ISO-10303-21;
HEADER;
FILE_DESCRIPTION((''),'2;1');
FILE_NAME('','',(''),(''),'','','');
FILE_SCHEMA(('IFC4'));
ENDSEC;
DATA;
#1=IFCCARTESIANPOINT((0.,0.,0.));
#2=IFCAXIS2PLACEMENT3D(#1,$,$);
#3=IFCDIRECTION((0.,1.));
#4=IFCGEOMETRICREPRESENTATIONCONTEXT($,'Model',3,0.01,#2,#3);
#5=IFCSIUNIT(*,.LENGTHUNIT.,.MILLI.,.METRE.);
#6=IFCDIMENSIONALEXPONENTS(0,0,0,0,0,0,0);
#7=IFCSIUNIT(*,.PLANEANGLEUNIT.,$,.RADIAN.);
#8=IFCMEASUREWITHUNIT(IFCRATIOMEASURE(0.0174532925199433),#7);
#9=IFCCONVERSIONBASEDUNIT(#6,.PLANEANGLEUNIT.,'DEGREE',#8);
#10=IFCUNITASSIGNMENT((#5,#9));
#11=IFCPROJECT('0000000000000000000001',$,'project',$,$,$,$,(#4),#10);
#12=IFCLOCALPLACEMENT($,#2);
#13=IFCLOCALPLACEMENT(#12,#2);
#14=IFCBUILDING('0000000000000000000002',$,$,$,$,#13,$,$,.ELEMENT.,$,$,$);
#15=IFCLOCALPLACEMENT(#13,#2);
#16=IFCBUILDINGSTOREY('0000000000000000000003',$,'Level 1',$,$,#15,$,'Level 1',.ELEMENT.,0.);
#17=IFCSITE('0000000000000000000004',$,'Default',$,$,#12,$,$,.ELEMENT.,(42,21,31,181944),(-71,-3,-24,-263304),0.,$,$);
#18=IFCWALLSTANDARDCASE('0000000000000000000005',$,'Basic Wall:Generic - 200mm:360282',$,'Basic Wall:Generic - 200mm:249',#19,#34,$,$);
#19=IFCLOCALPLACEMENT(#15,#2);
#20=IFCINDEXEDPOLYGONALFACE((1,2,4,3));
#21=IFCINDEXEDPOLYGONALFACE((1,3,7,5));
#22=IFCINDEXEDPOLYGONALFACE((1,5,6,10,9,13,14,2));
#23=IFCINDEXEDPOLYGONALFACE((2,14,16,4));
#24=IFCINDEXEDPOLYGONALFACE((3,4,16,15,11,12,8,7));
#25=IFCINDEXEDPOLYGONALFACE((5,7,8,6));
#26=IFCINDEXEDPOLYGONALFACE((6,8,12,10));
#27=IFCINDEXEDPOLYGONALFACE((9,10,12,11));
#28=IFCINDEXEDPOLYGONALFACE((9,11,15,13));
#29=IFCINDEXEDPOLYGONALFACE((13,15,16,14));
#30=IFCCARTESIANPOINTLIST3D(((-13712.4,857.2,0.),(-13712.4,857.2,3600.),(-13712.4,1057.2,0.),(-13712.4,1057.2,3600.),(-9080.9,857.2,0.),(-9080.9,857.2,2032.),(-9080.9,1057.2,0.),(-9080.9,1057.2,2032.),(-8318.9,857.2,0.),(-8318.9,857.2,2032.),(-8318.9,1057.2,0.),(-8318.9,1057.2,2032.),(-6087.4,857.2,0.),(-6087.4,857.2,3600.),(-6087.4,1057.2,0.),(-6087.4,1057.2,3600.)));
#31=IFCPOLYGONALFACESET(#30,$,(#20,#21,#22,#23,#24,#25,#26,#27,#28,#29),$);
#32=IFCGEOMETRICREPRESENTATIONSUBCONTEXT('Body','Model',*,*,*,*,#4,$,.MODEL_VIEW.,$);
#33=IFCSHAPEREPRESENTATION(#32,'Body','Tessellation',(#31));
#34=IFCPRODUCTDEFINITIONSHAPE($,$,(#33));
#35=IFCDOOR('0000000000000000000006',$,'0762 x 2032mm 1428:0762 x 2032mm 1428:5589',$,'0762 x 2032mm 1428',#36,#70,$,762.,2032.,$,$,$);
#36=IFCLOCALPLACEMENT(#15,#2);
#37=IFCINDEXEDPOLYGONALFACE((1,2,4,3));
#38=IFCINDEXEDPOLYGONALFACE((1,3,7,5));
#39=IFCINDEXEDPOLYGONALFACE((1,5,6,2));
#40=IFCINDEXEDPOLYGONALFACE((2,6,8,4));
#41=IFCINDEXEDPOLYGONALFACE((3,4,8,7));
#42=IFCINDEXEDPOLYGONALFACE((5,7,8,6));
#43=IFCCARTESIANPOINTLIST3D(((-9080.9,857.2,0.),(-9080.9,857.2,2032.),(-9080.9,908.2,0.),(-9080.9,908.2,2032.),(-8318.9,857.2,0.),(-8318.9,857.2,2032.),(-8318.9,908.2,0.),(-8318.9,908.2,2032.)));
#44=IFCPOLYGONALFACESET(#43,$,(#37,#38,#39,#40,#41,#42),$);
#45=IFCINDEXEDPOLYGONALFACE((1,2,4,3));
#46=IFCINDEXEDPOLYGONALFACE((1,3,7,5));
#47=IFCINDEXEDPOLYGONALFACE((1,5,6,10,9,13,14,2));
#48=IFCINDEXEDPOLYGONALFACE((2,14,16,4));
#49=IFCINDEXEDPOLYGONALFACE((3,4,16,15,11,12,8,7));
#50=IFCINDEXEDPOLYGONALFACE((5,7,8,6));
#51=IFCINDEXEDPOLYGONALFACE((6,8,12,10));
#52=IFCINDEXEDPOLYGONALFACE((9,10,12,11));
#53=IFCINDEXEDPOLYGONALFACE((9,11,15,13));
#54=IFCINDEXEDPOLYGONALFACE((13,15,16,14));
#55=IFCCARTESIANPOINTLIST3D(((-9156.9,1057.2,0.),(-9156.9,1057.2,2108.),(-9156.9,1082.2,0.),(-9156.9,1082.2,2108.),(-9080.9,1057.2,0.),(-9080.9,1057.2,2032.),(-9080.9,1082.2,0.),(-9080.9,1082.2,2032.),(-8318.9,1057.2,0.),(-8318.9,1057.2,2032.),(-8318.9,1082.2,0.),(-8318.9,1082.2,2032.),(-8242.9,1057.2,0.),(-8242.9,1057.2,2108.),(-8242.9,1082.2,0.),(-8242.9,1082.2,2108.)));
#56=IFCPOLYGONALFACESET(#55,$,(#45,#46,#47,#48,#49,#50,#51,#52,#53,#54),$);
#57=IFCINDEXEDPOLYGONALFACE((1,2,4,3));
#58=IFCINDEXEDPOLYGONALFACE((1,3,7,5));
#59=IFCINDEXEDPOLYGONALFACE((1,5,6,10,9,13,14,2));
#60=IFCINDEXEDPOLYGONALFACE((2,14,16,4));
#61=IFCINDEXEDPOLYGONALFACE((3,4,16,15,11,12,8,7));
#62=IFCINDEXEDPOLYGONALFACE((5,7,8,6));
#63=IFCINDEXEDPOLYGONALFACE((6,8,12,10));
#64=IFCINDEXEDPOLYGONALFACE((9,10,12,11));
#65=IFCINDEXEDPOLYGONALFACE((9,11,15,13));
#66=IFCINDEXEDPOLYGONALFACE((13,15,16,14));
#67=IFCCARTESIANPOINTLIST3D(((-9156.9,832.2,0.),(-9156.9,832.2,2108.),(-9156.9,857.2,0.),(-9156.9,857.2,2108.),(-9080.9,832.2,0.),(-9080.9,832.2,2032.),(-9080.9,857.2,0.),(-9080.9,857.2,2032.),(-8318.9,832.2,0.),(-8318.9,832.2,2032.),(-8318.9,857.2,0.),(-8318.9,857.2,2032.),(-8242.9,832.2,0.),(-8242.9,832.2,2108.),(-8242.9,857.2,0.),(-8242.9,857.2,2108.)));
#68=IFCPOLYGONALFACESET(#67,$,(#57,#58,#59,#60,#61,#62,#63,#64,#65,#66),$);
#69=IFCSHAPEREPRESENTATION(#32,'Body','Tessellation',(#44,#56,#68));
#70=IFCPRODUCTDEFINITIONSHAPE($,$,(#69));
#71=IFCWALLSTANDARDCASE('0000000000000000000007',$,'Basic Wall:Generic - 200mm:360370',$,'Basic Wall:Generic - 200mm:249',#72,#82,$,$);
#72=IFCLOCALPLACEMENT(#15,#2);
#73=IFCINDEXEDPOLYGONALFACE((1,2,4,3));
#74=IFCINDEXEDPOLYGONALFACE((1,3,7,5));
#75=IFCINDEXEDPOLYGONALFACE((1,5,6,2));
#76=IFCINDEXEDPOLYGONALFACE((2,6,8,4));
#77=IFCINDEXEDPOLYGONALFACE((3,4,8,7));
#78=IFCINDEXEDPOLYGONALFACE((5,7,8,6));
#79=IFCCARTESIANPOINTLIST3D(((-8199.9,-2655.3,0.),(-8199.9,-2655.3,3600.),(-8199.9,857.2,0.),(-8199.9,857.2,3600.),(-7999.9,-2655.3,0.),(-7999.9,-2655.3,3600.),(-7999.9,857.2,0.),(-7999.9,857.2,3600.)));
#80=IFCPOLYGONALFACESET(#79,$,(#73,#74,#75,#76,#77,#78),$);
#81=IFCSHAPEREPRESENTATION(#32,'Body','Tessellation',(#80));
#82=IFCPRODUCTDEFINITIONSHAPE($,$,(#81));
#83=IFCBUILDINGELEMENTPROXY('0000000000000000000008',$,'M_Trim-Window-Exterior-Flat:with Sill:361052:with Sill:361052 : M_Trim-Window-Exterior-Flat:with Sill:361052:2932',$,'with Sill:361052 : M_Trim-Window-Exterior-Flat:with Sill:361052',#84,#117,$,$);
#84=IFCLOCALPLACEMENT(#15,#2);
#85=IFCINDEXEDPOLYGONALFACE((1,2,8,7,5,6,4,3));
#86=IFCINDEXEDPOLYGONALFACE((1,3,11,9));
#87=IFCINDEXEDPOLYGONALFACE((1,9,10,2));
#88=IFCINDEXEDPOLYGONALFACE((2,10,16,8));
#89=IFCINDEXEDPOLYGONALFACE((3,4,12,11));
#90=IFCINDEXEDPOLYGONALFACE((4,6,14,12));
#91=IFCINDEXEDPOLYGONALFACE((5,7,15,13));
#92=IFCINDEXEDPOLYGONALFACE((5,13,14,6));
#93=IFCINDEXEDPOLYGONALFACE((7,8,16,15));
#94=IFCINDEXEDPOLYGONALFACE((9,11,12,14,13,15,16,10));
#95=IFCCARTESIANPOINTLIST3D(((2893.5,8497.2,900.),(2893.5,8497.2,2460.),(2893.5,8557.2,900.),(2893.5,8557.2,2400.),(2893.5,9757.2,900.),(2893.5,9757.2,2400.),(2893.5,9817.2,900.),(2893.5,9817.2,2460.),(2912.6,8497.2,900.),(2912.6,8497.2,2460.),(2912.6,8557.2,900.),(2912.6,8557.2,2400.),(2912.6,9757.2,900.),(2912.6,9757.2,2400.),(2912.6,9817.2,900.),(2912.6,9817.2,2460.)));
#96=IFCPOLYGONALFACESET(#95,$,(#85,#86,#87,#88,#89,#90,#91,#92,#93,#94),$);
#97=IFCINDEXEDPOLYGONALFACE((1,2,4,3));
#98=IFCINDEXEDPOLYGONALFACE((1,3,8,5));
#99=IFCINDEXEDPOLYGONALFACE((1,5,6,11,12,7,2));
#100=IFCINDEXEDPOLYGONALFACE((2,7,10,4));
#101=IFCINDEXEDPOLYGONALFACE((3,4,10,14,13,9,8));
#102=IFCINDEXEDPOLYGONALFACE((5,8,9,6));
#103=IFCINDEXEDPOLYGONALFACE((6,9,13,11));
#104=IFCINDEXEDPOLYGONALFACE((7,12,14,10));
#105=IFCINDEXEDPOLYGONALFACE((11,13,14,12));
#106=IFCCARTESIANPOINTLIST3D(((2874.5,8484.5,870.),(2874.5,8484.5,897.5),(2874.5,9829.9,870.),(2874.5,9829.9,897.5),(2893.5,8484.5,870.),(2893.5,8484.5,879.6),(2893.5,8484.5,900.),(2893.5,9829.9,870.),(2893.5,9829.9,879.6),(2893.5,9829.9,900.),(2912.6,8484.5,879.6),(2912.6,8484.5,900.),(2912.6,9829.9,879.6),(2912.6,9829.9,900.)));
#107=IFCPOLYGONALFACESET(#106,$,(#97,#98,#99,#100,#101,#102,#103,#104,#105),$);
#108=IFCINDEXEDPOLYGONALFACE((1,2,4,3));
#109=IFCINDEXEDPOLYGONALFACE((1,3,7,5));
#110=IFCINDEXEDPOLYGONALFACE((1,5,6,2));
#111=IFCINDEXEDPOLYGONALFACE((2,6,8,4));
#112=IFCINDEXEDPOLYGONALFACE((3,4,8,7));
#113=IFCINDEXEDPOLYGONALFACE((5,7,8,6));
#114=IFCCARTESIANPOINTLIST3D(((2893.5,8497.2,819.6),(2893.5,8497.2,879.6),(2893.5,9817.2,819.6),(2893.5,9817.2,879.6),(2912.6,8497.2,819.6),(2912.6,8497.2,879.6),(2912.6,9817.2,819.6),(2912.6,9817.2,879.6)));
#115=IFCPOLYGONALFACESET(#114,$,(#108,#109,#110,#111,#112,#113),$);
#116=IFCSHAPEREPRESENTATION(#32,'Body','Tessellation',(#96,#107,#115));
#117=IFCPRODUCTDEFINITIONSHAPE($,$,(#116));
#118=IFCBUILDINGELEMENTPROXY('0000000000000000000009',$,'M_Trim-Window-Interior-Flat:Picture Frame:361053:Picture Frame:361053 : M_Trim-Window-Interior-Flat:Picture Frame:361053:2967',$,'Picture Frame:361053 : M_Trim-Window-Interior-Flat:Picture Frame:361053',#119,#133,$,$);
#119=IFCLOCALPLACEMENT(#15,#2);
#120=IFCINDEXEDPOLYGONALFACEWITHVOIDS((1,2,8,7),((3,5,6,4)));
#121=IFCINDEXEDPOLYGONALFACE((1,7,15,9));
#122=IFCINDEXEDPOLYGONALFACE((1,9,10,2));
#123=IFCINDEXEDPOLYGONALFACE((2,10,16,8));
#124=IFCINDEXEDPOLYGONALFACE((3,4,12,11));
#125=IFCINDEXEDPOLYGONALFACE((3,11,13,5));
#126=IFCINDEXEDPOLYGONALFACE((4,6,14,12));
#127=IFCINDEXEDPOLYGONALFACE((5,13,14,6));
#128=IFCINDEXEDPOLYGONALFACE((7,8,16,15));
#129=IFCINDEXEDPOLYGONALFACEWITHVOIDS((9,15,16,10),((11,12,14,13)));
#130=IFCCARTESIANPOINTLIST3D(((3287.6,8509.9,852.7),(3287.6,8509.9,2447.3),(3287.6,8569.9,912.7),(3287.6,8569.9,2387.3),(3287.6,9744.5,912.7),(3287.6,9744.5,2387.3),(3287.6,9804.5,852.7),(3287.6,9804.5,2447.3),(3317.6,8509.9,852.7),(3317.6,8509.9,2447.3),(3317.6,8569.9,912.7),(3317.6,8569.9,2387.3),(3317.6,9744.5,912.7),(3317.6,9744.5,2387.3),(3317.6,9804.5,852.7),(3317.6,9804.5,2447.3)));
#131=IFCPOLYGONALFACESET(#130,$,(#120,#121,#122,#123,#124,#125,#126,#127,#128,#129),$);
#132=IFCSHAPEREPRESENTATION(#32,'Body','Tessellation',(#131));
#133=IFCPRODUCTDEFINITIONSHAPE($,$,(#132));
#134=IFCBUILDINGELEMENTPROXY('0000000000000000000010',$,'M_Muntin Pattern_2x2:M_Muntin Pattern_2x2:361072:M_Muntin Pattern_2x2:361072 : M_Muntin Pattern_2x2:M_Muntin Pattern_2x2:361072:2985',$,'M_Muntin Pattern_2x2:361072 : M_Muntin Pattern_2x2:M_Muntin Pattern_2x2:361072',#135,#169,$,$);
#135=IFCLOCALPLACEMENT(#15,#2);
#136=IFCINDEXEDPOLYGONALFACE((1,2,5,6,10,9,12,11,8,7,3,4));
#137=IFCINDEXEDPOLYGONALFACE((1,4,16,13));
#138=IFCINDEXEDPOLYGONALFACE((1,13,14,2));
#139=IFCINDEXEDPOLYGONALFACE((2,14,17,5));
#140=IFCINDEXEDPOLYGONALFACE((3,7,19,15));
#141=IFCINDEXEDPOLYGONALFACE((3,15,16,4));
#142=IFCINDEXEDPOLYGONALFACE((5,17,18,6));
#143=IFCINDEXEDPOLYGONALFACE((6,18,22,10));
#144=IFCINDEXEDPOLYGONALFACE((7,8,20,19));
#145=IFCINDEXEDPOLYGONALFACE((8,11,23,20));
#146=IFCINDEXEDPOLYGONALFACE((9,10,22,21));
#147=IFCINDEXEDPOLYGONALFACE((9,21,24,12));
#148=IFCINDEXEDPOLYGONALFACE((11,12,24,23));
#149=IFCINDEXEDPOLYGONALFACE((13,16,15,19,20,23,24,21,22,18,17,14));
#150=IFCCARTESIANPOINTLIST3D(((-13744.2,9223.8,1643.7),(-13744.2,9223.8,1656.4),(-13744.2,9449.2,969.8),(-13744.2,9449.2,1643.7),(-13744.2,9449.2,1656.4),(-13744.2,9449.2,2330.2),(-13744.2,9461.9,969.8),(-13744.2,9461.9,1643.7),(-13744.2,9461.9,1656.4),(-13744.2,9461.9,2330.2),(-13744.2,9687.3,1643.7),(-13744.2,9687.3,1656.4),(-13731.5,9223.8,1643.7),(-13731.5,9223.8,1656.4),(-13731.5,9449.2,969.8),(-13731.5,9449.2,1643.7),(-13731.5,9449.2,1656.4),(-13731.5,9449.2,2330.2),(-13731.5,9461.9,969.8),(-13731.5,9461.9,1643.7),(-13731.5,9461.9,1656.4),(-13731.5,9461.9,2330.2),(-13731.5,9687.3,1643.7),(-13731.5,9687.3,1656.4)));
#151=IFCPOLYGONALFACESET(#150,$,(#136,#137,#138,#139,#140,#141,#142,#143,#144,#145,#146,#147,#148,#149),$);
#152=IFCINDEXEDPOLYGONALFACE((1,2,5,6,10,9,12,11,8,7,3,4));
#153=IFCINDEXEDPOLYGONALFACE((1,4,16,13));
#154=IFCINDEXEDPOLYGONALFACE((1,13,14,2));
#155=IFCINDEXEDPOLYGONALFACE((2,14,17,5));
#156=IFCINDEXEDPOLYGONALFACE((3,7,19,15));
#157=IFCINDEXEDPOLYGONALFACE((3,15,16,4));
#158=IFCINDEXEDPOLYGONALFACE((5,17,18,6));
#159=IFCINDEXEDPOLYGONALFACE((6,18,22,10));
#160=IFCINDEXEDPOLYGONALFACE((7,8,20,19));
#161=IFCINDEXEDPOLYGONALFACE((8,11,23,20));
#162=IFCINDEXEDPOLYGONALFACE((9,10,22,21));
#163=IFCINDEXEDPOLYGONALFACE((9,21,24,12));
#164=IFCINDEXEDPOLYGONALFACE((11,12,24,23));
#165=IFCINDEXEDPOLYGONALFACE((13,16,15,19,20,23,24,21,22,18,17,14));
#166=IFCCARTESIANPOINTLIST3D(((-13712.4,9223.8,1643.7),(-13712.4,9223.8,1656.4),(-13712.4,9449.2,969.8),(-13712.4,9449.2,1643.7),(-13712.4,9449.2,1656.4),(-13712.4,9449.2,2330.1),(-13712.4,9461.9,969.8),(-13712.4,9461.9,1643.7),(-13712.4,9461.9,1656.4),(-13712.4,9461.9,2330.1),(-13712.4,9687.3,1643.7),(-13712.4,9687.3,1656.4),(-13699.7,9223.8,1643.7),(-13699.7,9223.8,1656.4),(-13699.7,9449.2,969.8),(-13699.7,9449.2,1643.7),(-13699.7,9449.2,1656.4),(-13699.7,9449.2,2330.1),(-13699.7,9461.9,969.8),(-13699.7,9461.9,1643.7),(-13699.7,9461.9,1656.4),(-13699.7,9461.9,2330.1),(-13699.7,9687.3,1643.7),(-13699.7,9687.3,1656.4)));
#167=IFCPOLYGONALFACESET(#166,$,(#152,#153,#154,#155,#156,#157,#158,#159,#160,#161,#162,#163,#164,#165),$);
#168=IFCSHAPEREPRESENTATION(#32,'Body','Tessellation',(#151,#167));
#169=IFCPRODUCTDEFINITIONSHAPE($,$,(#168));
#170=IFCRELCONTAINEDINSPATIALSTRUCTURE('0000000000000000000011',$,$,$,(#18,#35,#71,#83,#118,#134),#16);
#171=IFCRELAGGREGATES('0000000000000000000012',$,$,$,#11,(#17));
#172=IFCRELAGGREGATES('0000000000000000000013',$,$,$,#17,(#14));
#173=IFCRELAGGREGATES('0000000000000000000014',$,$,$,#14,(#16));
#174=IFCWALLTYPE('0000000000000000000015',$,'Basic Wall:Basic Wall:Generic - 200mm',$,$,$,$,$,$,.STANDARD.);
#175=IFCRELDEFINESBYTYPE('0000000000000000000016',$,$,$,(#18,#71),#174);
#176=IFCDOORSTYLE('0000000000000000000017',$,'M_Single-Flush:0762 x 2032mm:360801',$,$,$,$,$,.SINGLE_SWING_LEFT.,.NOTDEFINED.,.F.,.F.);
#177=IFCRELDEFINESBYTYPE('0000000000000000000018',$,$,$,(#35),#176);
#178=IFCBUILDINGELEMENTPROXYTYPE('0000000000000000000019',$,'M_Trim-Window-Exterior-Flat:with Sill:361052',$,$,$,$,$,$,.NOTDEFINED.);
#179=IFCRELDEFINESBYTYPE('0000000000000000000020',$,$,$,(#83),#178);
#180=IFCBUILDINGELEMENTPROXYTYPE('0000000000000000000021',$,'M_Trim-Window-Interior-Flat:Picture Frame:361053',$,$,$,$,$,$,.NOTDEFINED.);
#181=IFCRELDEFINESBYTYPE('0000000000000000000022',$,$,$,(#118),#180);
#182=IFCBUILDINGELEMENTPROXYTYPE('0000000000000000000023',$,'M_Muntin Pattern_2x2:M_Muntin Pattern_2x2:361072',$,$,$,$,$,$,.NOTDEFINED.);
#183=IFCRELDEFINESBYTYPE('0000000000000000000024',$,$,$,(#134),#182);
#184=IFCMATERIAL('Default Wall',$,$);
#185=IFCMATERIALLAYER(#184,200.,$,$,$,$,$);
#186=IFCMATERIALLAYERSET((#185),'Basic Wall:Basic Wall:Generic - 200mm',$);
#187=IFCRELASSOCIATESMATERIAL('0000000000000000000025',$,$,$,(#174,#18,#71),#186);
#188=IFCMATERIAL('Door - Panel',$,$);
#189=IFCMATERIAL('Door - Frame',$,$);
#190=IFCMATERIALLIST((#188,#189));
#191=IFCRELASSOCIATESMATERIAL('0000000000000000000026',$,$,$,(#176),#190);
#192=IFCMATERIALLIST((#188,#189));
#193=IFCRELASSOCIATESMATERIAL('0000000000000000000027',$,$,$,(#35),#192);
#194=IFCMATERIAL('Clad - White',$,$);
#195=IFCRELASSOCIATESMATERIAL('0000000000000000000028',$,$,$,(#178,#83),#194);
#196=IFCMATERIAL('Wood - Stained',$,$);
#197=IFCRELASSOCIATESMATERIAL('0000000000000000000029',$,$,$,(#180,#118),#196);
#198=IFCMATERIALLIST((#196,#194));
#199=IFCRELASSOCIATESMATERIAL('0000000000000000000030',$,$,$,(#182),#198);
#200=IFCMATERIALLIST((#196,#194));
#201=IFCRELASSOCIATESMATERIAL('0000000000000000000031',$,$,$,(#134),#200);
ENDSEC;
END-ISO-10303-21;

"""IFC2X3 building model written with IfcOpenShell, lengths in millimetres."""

from ifc_helpers import new_model, entity, si_unit, converted_unit, direction, frame, frame_2d, origin, origin_2d_with_axis, place, context, subcontext, project, spatial, polyline, rectangle, outline, extrude, source, transform, mapped, material, material_list, layer, layer_set, layer_usage, type_object, type_shapes, element, fill, save


model = new_model("IFC2X3")

# Units and contexts
model_context = context("Model", 3, precision=0.01, world=origin(), true_north=direction((0.0, 1.0)))
body_context = subcontext(model_context, "Body", "Model", "MODEL_VIEW")
ifc_project = project(units=[si_unit("LENGTHUNIT", "METRE", prefix="MILLI"), converted_unit("PLANEANGLEUNIT", "DEGREE", entity("IfcRatioMeasure", 0.0174532925199433), si_unit("PLANEANGLEUNIT", "RADIAN"), dimensions=[0, 0, 0, 0, 0, 0, 0])], contexts=[model_context])

# Site, building, storey
site_placement = place(None, origin())
site = spatial("IfcSite", under=ifc_project, at=site_placement, Name="Default", CompositionType="ELEMENT", RefLatitude=(42, 21, 31, 181944), RefLongitude=(-71, -3, -24, -263304), RefElevation=0.0)
building_placement = place(site_placement, origin())
building = spatial("IfcBuilding", under=site, at=building_placement, CompositionType="ELEMENT")
storey_placement = place(building_placement, origin())
storey = spatial("IfcBuildingStorey", under=building, at=storey_placement, Name="Level 1", LongName="Level 1", CompositionType="ELEMENT", Elevation=0.0)

# Shared definitions
ifc_material_1 = material(Name="Default Wall")
ifc_material_2 = material(Name="Door - Panel")
ifc_material_3 = material(Name="Door - Frame")

# Shared definitions
ifc_layer_1 = layer(ifc_material_1, 200.0)
ifc_layer_set_1 = layer_set([ifc_layer_1], Name="Basic Wall:Basic Wall:Generic - 200mm")
wall_type_1 = type_object("IfcWallType", Name="Basic Wall:Basic Wall:Generic - 200mm", PredefinedType="STANDARD", material=ifc_layer_set_1)
ifc_material_list_1 = material_list([ifc_material_2, ifc_material_3])
door_style_1 = type_object("IfcDoorStyle", Name="M_Single-Flush:0762 x 2032mm:360801", ConstructionType="NOTDEFINED", OperationType="SINGLE_SWING_LEFT", ParameterTakesPrecedence=False, Sizeable=False, material=ifc_material_list_1)
shared_shape_1 = source(origin(), body_context, "Body", "SweptSolid", [
    extrude(rectangle(XDim=51.0, YDim=762.0, at=origin_2d_with_axis()), frame((381.0, -27.5, 0.0), z_axis=(0.0, 0.0, 1.0), x_axis=(0.0, 1.0, 0.0)), (0.0, 0.0, 1.0), 2032.0),
    extrude(outline(polyline([(-1035.0, -457.0), (1073.0, -457.0), (1073.0, 457.0), (-1035.0, 457.0), (-1035.0, 381.0), (997.0, 381.0), (997.0, -381.0), (-1035.0, -381.0), (-1035.0, -457.0)])), frame((381.0, -227.0, 1035.0), z_axis=(0.0, 1.0, 0.0), x_axis=(0.0, 0.0, 1.0)), (0.0, 0.0, 1.0), 25.0),
    extrude(outline(polyline([(-457.0, -1073.0), (457.0, -1073.0), (457.0, 1035.0), (381.0, 1035.0), (381.0, -997.0), (-381.0, -997.0), (-381.0, 1035.0), (-457.0, 1035.0), (-457.0, -1073.0)])), frame((381.0, -2.0, 1035.0), z_axis=(0.0, 1.0, 0.0), x_axis=(1.0, 0.0, 0.0)), (0.0, 0.0, 1.0), 25.0),
])
type_shapes(door_style_1, [shared_shape_1])

# Wall, opening, door
ifc_layer_usage_1 = layer_usage(ifc_layer_set_1, "AXIS2", "NEGATIVE", 100.0)
wall_1_placement = place(storey_placement, frame((-6087.4, 957.2, 0.0), z_axis=(0.0, 0.0, 1.0), x_axis=(-1.0, 0.0, 0.0)))
wall_1 = element("IfcWallStandardCase", 1, at=wall_1_placement, inside=storey, type_object=wall_type_1, material=ifc_layer_usage_1, Name="Basic Wall:Generic - 200mm:360282", ObjectType="Basic Wall:Generic - 200mm:249", context=body_context, shape_type="SweptSolid", body=[
    extrude(rectangle(XDim=7625.0, YDim=200.0, at=frame_2d((3812.5, 0.0), x_axis=(-1.0, 0.0))), origin(), (0.0, 0.0, 1.0), 3600.0),
])
opening_1_placement = place(wall_1_placement, frame((-6087.4, 957.2, 0.0), z_axis=(0.0, 0.0, 1.0), x_axis=(-1.0, 0.0, 0.0)))
opening_1 = element("IfcOpeningElement", 2, at=opening_1_placement, cuts=wall_1, ObjectType="Opening", context=body_context, shape_type="SweptSolid", body=[
    extrude(rectangle(XDim=2032.0, YDim=762.0, at=origin_2d_with_axis()), frame((-8699.9, 1059.2, 1016.0), z_axis=(0.0, -1.0, 0.0), x_axis=(0.0, 0.0, 1.0)), (0.0, 0.0, 1.0), 204.0),
])
ifc_material_list_2 = material_list([ifc_material_2, ifc_material_3])
door_1_placement = place(opening_1_placement, frame((-8318.9, 855.2, 0.0), z_axis=(0.0, 0.0, 1.0), x_axis=(-1.0, 0.0, 0.0)))
door_1 = element("IfcDoor", 3, at=door_1_placement, inside=storey, type_object=door_style_1, material=ifc_material_list_2, Name="0762 x 2032mm 1428:0762 x 2032mm 1428:5589", ObjectType="0762 x 2032mm 1428", OverallHeight=762.0, OverallWidth=2032.0, context=body_context, shape_type="MappedRepresentation", body=[
    mapped(shared_shape_1, transform((0.0, 0.0, 0.0), scale=1.0)),
])
fill(opening_1, door_1)

# Wall
ifc_layer_usage_2 = layer_usage(ifc_layer_set_1, "AXIS2", "NEGATIVE", 100.0)
wall_2_placement = place(storey_placement, frame((-8099.9, 857.2, 0.0), z_axis=(0.0, 0.0, 1.0), x_axis=(0.0, -1.0, 0.0)))
element("IfcWallStandardCase", 4, at=wall_2_placement, inside=storey, type_object=wall_type_1, material=ifc_layer_usage_2, Name="Basic Wall:Generic - 200mm:360370", ObjectType="Basic Wall:Generic - 200mm:249", context=body_context, shape_type="SweptSolid", body=[
    extrude(rectangle(XDim=3512.5, YDim=200.0, at=frame_2d((1756.2, 0.0), x_axis=(-1.0, 0.0))), origin(), (0.0, 0.0, 1.0), 3600.0),
])

# Building element proxies
ifc_material_4 = material(Name="Clad - White")
building_element_proxy_type_1 = type_object("IfcBuildingElementProxyType", Name="M_Trim-Window-Exterior-Flat:with Sill:361052", PredefinedType="NOTDEFINED", material=ifc_material_4)
shared_shape_2 = source(origin(), body_context, "Body", "SweptSolid", [
    extrude(outline(polyline([(-765.0, -660.0), (795.0, -660.0), (795.0, 660.0), (-765.0, 660.0), (-765.0, 600.0), (735.0, 600.0), (735.0, -600.0), (-765.0, -600.0), (-765.0, -660.0)])), frame((2893.5, 9157.2, 1665.0), z_axis=(1.0, 0.0, 0.0), x_axis=(0.0, 0.0, 1.0)), (0.0, 0.0, 1.0), 19.1),
    extrude(outline(polyline([(0.0, -15.2), (19.0, -15.2), (19.0, 12.3), (0.0, 14.8), (-19.0, 14.8), (-19.0, -5.7), (0.0, -5.7), (0.0, -15.2)])), frame((2893.5, 8484.5, 885.2), z_axis=(0.0, 1.0, 0.0), x_axis=(-1.0, 0.0, 0.0)), (0.0, 0.0, 1.0), 1345.4),
    extrude(rectangle(XDim=19.1, YDim=1320.0, at=frame_2d((0.0, 0.0), x_axis=(1.0, 0.0))), frame((2903.0, 9157.2, 819.6)), (0.0, 0.0, 1.0), 60.0),
])
type_shapes(building_element_proxy_type_1, [shared_shape_2])
proxy_1_placement = place(storey_placement, origin())
element("IfcBuildingElementProxy", 5, at=proxy_1_placement, inside=storey, type_object=building_element_proxy_type_1, material=ifc_material_4, Name="M_Trim-Window-Exterior-Flat:with Sill:361052:with Sill:361052 : M_Trim-Window-Exterior-Flat:with Sill:361052:2932", ObjectType="with Sill:361052 : M_Trim-Window-Exterior-Flat:with Sill:361052", context=body_context, shape_type="MappedRepresentation", body=[
    mapped(shared_shape_2, transform((0.0, 0.0, 0.0), scale=1.0)),
])
ifc_material_5 = material(Name="Wood - Stained")
building_element_proxy_type_2 = type_object("IfcBuildingElementProxyType", Name="M_Trim-Window-Interior-Flat:Picture Frame:361053", PredefinedType="NOTDEFINED", material=ifc_material_5)
shared_shape_3 = source(origin(), body_context, "Body", "SweptSolid", [
    extrude(outline(polyline([(-797.3, -647.3), (797.3, -647.3), (797.3, 647.3), (-797.3, 647.3), (-797.3, -647.3)]), holes=[polyline([(737.3, 587.3), (737.3, -587.3), (-737.3, -587.3), (-737.3, 587.3), (737.3, 587.3)])]), frame((3287.6, 9157.2, 1650.0), z_axis=(1.0, 0.0, 0.0), x_axis=(0.0, 0.0, -1.0)), (0.0, 0.0, 1.0), 30.0),
])
type_shapes(building_element_proxy_type_2, [shared_shape_3])
proxy_2_placement = place(storey_placement, origin())
element("IfcBuildingElementProxy", 6, at=proxy_2_placement, inside=storey, type_object=building_element_proxy_type_2, material=ifc_material_5, Name="M_Trim-Window-Interior-Flat:Picture Frame:361053:Picture Frame:361053 : M_Trim-Window-Interior-Flat:Picture Frame:361053:2967", ObjectType="Picture Frame:361053 : M_Trim-Window-Interior-Flat:Picture Frame:361053", context=body_context, shape_type="MappedRepresentation", body=[
    mapped(shared_shape_3, transform((0.0, 0.0, 0.0), scale=1.0)),
])
ifc_material_list_3 = material_list([ifc_material_5, ifc_material_4])
ifc_material_list_4 = material_list([ifc_material_5, ifc_material_4])
building_element_proxy_type_3 = type_object("IfcBuildingElementProxyType", Name="M_Muntin Pattern_2x2:M_Muntin Pattern_2x2:361072", PredefinedType="NOTDEFINED", material=ifc_material_list_4)
shared_shape_4 = source(origin(), body_context, "Body", "SweptSolid", [
    extrude(outline(polyline([(-6.4, -680.2), (6.3, -680.2), (6.3, -6.4), (231.7, -6.4), (231.7, 6.3), (6.3, 6.3), (6.3, 680.2), (-6.4, 680.2), (-6.4, 6.3), (-231.7, 6.3), (-231.7, -6.4), (-6.4, -6.4), (-6.4, -680.2)])), frame((-13744.2, 9455.6, 1650.0), z_axis=(1.0, 0.0, 0.0), x_axis=(0.0, -1.0, 0.0)), (0.0, 0.0, 1.0), 12.7),
    extrude(outline(polyline([(-6.4, -680.1), (6.3, -680.1), (6.3, -6.4), (231.7, -6.4), (231.7, 6.3), (6.3, 6.3), (6.3, 680.2), (-6.4, 680.2), (-6.4, 6.3), (-231.7, 6.3), (-231.7, -6.4), (-6.4, -6.4), (-6.4, -680.1)])), frame((-13712.4, 9455.6, 1650.0), z_axis=(1.0, 0.0, 0.0), x_axis=(0.0, -1.0, 0.0)), (0.0, 0.0, 1.0), 12.7),
])
type_shapes(building_element_proxy_type_3, [shared_shape_4])
proxy_3_placement = place(storey_placement, origin())
element("IfcBuildingElementProxy", 7, at=proxy_3_placement, inside=storey, type_object=building_element_proxy_type_3, material=ifc_material_list_3, Name="M_Muntin Pattern_2x2:M_Muntin Pattern_2x2:361072:M_Muntin Pattern_2x2:361072 : M_Muntin Pattern_2x2:M_Muntin Pattern_2x2:361072:2985", ObjectType="M_Muntin Pattern_2x2:361072 : M_Muntin Pattern_2x2:M_Muntin Pattern_2x2:361072", context=body_context, shape_type="MappedRepresentation", body=[
    mapped(shared_shape_4, transform((0.0, 0.0, 0.0), scale=1.0)),
])

save(model, "model.ifc")
